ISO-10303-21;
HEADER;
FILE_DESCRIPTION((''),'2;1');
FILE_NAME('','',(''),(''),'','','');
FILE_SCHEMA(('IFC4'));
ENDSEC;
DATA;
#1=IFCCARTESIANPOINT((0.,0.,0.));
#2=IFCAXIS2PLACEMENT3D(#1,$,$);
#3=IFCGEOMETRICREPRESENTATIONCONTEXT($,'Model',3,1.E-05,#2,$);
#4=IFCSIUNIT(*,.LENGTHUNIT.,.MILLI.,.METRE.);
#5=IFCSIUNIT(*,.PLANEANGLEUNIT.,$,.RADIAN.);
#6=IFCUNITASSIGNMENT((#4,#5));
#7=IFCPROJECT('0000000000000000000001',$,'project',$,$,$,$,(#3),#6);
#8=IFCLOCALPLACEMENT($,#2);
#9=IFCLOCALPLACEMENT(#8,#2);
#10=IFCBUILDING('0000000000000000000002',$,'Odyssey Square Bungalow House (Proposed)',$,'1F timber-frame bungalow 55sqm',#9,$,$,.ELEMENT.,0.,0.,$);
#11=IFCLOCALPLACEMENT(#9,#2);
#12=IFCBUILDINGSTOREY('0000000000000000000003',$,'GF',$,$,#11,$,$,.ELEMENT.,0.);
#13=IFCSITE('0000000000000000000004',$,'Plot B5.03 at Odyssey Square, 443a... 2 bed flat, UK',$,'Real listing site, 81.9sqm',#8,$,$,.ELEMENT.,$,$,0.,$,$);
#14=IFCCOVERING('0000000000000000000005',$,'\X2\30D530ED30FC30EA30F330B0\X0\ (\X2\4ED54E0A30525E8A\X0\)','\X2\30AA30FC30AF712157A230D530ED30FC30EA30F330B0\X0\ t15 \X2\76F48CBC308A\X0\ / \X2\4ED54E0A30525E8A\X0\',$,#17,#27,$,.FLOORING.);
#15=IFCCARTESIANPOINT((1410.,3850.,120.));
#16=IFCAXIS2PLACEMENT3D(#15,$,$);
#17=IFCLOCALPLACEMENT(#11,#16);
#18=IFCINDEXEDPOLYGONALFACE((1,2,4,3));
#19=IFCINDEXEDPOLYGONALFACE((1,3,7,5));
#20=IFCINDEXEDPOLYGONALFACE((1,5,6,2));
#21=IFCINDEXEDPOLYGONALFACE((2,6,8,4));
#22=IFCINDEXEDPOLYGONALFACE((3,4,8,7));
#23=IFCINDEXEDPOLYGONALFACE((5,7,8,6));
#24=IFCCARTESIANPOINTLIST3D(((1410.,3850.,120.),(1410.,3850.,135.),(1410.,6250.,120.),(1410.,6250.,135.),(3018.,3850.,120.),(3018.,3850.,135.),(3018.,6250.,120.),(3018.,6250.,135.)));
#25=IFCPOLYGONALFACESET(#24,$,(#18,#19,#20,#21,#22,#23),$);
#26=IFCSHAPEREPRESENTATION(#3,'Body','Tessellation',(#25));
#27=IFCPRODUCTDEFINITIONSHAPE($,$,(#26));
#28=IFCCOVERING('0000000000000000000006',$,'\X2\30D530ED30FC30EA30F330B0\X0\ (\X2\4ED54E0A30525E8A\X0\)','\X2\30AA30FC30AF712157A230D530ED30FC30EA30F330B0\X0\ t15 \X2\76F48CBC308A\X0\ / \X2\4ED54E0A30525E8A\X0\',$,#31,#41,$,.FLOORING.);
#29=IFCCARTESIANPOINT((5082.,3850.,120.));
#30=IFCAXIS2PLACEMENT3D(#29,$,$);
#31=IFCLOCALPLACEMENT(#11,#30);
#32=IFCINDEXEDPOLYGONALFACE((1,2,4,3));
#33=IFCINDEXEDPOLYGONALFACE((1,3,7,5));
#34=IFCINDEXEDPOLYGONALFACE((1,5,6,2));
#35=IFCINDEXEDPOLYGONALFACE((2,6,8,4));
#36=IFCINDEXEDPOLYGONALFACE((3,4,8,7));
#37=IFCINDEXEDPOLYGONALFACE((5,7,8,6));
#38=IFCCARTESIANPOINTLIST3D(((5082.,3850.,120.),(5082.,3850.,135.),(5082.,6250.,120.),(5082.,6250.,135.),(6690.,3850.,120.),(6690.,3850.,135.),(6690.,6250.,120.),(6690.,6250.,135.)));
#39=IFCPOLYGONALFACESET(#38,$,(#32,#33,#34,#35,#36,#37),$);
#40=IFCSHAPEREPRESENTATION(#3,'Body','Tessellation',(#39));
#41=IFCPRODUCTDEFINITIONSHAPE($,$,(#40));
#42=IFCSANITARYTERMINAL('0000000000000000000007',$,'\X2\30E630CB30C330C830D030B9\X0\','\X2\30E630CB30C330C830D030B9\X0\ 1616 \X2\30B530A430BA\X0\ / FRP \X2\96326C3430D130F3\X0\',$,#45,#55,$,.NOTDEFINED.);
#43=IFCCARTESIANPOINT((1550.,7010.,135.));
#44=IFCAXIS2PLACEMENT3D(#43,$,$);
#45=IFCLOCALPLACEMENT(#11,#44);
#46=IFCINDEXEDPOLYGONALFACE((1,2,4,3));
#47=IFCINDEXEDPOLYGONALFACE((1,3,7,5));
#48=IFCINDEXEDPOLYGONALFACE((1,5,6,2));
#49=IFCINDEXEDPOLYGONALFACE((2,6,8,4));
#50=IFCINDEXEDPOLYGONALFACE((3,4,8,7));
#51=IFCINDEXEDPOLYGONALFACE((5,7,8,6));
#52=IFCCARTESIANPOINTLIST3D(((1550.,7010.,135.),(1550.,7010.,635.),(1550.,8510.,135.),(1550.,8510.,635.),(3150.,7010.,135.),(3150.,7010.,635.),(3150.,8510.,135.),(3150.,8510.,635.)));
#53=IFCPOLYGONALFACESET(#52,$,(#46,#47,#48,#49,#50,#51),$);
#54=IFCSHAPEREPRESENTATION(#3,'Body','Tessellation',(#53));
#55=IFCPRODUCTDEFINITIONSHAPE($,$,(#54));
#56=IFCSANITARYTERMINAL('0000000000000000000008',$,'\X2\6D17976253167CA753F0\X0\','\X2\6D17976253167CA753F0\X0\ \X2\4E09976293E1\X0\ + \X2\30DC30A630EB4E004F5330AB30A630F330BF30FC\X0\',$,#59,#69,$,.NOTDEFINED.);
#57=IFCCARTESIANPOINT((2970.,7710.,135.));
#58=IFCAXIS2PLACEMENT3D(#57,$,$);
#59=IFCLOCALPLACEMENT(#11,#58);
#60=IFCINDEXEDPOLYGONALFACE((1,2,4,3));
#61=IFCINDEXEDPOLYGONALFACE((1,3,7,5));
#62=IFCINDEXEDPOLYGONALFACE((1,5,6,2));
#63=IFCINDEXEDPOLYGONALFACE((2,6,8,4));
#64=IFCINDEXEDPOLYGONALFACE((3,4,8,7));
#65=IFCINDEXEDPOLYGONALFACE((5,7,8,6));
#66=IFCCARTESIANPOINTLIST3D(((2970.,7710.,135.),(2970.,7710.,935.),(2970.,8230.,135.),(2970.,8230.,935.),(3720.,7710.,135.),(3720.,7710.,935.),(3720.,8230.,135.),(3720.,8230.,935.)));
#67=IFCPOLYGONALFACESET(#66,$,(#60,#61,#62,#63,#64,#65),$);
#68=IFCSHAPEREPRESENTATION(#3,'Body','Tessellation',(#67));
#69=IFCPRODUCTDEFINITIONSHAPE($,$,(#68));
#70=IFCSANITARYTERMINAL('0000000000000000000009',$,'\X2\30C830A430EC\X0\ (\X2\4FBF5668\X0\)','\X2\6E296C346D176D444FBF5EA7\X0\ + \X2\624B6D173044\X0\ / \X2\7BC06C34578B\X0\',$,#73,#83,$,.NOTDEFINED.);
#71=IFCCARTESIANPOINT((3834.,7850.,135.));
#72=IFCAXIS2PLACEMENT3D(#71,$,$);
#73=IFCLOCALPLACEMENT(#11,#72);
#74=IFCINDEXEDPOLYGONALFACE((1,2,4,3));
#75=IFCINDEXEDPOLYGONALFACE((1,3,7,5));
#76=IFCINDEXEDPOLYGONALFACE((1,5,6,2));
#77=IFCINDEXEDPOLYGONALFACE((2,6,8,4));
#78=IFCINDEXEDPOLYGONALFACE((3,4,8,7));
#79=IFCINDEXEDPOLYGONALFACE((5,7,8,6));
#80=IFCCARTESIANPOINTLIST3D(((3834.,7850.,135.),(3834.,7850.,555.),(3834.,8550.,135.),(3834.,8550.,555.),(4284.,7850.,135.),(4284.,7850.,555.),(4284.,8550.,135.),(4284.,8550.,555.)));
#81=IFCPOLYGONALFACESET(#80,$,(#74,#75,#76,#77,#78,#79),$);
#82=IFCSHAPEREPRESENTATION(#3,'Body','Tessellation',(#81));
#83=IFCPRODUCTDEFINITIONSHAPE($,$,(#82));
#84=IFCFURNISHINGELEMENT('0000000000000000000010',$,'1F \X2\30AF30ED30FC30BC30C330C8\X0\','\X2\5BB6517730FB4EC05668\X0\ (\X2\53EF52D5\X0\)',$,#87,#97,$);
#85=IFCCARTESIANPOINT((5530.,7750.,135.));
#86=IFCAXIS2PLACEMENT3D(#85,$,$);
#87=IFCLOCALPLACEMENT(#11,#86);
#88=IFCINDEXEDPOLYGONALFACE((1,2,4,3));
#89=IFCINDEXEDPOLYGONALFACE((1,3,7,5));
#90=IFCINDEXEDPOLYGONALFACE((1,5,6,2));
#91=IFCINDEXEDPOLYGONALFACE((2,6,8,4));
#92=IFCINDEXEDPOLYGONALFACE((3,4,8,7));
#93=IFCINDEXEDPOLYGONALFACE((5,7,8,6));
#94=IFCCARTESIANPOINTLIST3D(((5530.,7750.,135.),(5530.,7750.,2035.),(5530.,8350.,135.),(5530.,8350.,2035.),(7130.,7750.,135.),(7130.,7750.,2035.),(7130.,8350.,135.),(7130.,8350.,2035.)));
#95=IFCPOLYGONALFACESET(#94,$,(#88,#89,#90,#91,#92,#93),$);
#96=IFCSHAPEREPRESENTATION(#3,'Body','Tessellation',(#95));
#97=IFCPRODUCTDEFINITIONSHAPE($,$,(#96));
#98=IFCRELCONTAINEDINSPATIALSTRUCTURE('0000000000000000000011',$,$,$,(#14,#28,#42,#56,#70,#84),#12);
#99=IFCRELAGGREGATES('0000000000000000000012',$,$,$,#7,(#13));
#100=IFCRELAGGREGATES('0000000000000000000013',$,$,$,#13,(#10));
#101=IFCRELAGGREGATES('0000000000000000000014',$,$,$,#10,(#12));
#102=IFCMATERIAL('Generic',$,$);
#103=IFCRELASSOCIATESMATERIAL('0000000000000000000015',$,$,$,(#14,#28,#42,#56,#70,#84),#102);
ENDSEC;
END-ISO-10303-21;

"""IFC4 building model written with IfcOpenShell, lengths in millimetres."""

from ifc_helpers import new_model, si_unit, frame, frame_2d, origin, place, context, project, spatial, rectangle, extrude, material, element, save


model = new_model("IFC4")

# Units and contexts
model_context = context("Model", 3, precision=1e-05, world=origin())
ifc_project = project(units=[si_unit("LENGTHUNIT", "METRE", prefix="MILLI"), si_unit("PLANEANGLEUNIT", "RADIAN")], contexts=[model_context])

# Site, building, storey
site_placement = place(None, origin())
site = spatial("IfcSite", under=ifc_project, at=site_placement, Name="Plot B5.03 at Odyssey Square, 443a... 2 bed flat, UK", ObjectType="Real listing site, 81.9sqm", CompositionType="ELEMENT", RefElevation=0.0)
building_placement = place(site_placement, origin())
building = spatial("IfcBuilding", under=site, at=building_placement, Name="Odyssey Square Bungalow House (Proposed)", ObjectType="1F timber-frame bungalow 55sqm", CompositionType="ELEMENT", ElevationOfRefHeight=0.0, ElevationOfTerrain=0.0)
storey_placement = place(building_placement, origin())
storey = spatial("IfcBuildingStorey", under=building, at=storey_placement, Name="GF", CompositionType="ELEMENT", Elevation=0.0)

# Coverings
ifc_material_1 = material(Name="Generic")
covering_1_placement = place(storey_placement, frame((1410.0, 3850.0, 120.0)))
element("IfcCovering", 1, at=covering_1_placement, inside=storey, material=ifc_material_1, Name="フローリング (仕上げ床)", Description="オーク無垢フローリング t15 直貼り / 仕上げ床", PredefinedType="FLOORING", context=model_context, shape_type="SweptSolid", body=[
    extrude(rectangle(XDim=1608.0, YDim=2400.0, at=frame_2d((804.0, 1200.0))), frame((1410.0, 3850.0, 120.0)), (0.0, 0.0, 1.0), 15.0),
])
covering_2_placement = place(storey_placement, frame((5082.0, 3850.0, 120.0)))
element("IfcCovering", 2, at=covering_2_placement, inside=storey, material=ifc_material_1, Name="フローリング (仕上げ床)", Description="オーク無垢フローリング t15 直貼り / 仕上げ床", PredefinedType="FLOORING", context=model_context, shape_type="SweptSolid", body=[
    extrude(rectangle(XDim=1608.0, YDim=2400.0, at=frame_2d((804.0, 1200.0))), frame((5082.0, 3850.0, 120.0)), (0.0, 0.0, 1.0), 15.0),
])

# Sanitary terminals
sanitary_terminal_1_placement = place(storey_placement, frame((1550.0, 7010.0, 135.0)))
element("IfcSanitaryTerminal", 3, at=sanitary_terminal_1_placement, inside=storey, material=ifc_material_1, Name="ユニットバス", Description="ユニットバス 1616 サイズ / FRP 防水パン", PredefinedType="NOTDEFINED", context=model_context, shape_type="SweptSolid", body=[
    extrude(rectangle(XDim=1600.0, YDim=1500.0, at=frame_2d((800.0, 750.0))), frame((1550.0, 7010.0, 135.0)), (0.0, 0.0, 1.0), 500.0),
])
sanitary_terminal_2_placement = place(storey_placement, frame((2970.0, 7710.0, 135.0)))
element("IfcSanitaryTerminal", 4, at=sanitary_terminal_2_placement, inside=storey, material=ifc_material_1, Name="洗面化粧台", Description="洗面化粧台 三面鏡 + ボウル一体カウンター", PredefinedType="NOTDEFINED", context=model_context, shape_type="SweptSolid", body=[
    extrude(rectangle(XDim=750.0, YDim=520.0, at=frame_2d((375.0, 260.0))), frame((2970.0, 7710.0, 135.0)), (0.0, 0.0, 1.0), 800.0),
])
sanitary_terminal_3_placement = place(storey_placement, frame((3834.0, 7850.0, 135.0)))
element("IfcSanitaryTerminal", 5, at=sanitary_terminal_3_placement, inside=storey, material=ifc_material_1, Name="トイレ (便器)", Description="温水洗浄便座 + 手洗い / 節水型", PredefinedType="NOTDEFINED", context=model_context, shape_type="SweptSolid", body=[
    extrude(rectangle(XDim=450.0, YDim=700.0, at=frame_2d((225.0, 350.0))), frame((3834.0, 7850.0, 135.0)), (0.0, 0.0, 1.0), 420.0),
])

# Furnishing element
furnishing_placement = place(storey_placement, frame((5530.0, 7750.0, 135.0)))
element("IfcFurnishingElement", 6, at=furnishing_placement, inside=storey, material=ifc_material_1, Name="1F クローゼット", Description="家具・什器 (可動)", context=model_context, shape_type="SweptSolid", body=[
    extrude(rectangle(XDim=1600.0, YDim=600.0, at=frame_2d((800.0, 300.0))), frame((5530.0, 7750.0, 135.0)), (0.0, 0.0, 1.0), 1900.0),
])

save(model, "model.ifc")
